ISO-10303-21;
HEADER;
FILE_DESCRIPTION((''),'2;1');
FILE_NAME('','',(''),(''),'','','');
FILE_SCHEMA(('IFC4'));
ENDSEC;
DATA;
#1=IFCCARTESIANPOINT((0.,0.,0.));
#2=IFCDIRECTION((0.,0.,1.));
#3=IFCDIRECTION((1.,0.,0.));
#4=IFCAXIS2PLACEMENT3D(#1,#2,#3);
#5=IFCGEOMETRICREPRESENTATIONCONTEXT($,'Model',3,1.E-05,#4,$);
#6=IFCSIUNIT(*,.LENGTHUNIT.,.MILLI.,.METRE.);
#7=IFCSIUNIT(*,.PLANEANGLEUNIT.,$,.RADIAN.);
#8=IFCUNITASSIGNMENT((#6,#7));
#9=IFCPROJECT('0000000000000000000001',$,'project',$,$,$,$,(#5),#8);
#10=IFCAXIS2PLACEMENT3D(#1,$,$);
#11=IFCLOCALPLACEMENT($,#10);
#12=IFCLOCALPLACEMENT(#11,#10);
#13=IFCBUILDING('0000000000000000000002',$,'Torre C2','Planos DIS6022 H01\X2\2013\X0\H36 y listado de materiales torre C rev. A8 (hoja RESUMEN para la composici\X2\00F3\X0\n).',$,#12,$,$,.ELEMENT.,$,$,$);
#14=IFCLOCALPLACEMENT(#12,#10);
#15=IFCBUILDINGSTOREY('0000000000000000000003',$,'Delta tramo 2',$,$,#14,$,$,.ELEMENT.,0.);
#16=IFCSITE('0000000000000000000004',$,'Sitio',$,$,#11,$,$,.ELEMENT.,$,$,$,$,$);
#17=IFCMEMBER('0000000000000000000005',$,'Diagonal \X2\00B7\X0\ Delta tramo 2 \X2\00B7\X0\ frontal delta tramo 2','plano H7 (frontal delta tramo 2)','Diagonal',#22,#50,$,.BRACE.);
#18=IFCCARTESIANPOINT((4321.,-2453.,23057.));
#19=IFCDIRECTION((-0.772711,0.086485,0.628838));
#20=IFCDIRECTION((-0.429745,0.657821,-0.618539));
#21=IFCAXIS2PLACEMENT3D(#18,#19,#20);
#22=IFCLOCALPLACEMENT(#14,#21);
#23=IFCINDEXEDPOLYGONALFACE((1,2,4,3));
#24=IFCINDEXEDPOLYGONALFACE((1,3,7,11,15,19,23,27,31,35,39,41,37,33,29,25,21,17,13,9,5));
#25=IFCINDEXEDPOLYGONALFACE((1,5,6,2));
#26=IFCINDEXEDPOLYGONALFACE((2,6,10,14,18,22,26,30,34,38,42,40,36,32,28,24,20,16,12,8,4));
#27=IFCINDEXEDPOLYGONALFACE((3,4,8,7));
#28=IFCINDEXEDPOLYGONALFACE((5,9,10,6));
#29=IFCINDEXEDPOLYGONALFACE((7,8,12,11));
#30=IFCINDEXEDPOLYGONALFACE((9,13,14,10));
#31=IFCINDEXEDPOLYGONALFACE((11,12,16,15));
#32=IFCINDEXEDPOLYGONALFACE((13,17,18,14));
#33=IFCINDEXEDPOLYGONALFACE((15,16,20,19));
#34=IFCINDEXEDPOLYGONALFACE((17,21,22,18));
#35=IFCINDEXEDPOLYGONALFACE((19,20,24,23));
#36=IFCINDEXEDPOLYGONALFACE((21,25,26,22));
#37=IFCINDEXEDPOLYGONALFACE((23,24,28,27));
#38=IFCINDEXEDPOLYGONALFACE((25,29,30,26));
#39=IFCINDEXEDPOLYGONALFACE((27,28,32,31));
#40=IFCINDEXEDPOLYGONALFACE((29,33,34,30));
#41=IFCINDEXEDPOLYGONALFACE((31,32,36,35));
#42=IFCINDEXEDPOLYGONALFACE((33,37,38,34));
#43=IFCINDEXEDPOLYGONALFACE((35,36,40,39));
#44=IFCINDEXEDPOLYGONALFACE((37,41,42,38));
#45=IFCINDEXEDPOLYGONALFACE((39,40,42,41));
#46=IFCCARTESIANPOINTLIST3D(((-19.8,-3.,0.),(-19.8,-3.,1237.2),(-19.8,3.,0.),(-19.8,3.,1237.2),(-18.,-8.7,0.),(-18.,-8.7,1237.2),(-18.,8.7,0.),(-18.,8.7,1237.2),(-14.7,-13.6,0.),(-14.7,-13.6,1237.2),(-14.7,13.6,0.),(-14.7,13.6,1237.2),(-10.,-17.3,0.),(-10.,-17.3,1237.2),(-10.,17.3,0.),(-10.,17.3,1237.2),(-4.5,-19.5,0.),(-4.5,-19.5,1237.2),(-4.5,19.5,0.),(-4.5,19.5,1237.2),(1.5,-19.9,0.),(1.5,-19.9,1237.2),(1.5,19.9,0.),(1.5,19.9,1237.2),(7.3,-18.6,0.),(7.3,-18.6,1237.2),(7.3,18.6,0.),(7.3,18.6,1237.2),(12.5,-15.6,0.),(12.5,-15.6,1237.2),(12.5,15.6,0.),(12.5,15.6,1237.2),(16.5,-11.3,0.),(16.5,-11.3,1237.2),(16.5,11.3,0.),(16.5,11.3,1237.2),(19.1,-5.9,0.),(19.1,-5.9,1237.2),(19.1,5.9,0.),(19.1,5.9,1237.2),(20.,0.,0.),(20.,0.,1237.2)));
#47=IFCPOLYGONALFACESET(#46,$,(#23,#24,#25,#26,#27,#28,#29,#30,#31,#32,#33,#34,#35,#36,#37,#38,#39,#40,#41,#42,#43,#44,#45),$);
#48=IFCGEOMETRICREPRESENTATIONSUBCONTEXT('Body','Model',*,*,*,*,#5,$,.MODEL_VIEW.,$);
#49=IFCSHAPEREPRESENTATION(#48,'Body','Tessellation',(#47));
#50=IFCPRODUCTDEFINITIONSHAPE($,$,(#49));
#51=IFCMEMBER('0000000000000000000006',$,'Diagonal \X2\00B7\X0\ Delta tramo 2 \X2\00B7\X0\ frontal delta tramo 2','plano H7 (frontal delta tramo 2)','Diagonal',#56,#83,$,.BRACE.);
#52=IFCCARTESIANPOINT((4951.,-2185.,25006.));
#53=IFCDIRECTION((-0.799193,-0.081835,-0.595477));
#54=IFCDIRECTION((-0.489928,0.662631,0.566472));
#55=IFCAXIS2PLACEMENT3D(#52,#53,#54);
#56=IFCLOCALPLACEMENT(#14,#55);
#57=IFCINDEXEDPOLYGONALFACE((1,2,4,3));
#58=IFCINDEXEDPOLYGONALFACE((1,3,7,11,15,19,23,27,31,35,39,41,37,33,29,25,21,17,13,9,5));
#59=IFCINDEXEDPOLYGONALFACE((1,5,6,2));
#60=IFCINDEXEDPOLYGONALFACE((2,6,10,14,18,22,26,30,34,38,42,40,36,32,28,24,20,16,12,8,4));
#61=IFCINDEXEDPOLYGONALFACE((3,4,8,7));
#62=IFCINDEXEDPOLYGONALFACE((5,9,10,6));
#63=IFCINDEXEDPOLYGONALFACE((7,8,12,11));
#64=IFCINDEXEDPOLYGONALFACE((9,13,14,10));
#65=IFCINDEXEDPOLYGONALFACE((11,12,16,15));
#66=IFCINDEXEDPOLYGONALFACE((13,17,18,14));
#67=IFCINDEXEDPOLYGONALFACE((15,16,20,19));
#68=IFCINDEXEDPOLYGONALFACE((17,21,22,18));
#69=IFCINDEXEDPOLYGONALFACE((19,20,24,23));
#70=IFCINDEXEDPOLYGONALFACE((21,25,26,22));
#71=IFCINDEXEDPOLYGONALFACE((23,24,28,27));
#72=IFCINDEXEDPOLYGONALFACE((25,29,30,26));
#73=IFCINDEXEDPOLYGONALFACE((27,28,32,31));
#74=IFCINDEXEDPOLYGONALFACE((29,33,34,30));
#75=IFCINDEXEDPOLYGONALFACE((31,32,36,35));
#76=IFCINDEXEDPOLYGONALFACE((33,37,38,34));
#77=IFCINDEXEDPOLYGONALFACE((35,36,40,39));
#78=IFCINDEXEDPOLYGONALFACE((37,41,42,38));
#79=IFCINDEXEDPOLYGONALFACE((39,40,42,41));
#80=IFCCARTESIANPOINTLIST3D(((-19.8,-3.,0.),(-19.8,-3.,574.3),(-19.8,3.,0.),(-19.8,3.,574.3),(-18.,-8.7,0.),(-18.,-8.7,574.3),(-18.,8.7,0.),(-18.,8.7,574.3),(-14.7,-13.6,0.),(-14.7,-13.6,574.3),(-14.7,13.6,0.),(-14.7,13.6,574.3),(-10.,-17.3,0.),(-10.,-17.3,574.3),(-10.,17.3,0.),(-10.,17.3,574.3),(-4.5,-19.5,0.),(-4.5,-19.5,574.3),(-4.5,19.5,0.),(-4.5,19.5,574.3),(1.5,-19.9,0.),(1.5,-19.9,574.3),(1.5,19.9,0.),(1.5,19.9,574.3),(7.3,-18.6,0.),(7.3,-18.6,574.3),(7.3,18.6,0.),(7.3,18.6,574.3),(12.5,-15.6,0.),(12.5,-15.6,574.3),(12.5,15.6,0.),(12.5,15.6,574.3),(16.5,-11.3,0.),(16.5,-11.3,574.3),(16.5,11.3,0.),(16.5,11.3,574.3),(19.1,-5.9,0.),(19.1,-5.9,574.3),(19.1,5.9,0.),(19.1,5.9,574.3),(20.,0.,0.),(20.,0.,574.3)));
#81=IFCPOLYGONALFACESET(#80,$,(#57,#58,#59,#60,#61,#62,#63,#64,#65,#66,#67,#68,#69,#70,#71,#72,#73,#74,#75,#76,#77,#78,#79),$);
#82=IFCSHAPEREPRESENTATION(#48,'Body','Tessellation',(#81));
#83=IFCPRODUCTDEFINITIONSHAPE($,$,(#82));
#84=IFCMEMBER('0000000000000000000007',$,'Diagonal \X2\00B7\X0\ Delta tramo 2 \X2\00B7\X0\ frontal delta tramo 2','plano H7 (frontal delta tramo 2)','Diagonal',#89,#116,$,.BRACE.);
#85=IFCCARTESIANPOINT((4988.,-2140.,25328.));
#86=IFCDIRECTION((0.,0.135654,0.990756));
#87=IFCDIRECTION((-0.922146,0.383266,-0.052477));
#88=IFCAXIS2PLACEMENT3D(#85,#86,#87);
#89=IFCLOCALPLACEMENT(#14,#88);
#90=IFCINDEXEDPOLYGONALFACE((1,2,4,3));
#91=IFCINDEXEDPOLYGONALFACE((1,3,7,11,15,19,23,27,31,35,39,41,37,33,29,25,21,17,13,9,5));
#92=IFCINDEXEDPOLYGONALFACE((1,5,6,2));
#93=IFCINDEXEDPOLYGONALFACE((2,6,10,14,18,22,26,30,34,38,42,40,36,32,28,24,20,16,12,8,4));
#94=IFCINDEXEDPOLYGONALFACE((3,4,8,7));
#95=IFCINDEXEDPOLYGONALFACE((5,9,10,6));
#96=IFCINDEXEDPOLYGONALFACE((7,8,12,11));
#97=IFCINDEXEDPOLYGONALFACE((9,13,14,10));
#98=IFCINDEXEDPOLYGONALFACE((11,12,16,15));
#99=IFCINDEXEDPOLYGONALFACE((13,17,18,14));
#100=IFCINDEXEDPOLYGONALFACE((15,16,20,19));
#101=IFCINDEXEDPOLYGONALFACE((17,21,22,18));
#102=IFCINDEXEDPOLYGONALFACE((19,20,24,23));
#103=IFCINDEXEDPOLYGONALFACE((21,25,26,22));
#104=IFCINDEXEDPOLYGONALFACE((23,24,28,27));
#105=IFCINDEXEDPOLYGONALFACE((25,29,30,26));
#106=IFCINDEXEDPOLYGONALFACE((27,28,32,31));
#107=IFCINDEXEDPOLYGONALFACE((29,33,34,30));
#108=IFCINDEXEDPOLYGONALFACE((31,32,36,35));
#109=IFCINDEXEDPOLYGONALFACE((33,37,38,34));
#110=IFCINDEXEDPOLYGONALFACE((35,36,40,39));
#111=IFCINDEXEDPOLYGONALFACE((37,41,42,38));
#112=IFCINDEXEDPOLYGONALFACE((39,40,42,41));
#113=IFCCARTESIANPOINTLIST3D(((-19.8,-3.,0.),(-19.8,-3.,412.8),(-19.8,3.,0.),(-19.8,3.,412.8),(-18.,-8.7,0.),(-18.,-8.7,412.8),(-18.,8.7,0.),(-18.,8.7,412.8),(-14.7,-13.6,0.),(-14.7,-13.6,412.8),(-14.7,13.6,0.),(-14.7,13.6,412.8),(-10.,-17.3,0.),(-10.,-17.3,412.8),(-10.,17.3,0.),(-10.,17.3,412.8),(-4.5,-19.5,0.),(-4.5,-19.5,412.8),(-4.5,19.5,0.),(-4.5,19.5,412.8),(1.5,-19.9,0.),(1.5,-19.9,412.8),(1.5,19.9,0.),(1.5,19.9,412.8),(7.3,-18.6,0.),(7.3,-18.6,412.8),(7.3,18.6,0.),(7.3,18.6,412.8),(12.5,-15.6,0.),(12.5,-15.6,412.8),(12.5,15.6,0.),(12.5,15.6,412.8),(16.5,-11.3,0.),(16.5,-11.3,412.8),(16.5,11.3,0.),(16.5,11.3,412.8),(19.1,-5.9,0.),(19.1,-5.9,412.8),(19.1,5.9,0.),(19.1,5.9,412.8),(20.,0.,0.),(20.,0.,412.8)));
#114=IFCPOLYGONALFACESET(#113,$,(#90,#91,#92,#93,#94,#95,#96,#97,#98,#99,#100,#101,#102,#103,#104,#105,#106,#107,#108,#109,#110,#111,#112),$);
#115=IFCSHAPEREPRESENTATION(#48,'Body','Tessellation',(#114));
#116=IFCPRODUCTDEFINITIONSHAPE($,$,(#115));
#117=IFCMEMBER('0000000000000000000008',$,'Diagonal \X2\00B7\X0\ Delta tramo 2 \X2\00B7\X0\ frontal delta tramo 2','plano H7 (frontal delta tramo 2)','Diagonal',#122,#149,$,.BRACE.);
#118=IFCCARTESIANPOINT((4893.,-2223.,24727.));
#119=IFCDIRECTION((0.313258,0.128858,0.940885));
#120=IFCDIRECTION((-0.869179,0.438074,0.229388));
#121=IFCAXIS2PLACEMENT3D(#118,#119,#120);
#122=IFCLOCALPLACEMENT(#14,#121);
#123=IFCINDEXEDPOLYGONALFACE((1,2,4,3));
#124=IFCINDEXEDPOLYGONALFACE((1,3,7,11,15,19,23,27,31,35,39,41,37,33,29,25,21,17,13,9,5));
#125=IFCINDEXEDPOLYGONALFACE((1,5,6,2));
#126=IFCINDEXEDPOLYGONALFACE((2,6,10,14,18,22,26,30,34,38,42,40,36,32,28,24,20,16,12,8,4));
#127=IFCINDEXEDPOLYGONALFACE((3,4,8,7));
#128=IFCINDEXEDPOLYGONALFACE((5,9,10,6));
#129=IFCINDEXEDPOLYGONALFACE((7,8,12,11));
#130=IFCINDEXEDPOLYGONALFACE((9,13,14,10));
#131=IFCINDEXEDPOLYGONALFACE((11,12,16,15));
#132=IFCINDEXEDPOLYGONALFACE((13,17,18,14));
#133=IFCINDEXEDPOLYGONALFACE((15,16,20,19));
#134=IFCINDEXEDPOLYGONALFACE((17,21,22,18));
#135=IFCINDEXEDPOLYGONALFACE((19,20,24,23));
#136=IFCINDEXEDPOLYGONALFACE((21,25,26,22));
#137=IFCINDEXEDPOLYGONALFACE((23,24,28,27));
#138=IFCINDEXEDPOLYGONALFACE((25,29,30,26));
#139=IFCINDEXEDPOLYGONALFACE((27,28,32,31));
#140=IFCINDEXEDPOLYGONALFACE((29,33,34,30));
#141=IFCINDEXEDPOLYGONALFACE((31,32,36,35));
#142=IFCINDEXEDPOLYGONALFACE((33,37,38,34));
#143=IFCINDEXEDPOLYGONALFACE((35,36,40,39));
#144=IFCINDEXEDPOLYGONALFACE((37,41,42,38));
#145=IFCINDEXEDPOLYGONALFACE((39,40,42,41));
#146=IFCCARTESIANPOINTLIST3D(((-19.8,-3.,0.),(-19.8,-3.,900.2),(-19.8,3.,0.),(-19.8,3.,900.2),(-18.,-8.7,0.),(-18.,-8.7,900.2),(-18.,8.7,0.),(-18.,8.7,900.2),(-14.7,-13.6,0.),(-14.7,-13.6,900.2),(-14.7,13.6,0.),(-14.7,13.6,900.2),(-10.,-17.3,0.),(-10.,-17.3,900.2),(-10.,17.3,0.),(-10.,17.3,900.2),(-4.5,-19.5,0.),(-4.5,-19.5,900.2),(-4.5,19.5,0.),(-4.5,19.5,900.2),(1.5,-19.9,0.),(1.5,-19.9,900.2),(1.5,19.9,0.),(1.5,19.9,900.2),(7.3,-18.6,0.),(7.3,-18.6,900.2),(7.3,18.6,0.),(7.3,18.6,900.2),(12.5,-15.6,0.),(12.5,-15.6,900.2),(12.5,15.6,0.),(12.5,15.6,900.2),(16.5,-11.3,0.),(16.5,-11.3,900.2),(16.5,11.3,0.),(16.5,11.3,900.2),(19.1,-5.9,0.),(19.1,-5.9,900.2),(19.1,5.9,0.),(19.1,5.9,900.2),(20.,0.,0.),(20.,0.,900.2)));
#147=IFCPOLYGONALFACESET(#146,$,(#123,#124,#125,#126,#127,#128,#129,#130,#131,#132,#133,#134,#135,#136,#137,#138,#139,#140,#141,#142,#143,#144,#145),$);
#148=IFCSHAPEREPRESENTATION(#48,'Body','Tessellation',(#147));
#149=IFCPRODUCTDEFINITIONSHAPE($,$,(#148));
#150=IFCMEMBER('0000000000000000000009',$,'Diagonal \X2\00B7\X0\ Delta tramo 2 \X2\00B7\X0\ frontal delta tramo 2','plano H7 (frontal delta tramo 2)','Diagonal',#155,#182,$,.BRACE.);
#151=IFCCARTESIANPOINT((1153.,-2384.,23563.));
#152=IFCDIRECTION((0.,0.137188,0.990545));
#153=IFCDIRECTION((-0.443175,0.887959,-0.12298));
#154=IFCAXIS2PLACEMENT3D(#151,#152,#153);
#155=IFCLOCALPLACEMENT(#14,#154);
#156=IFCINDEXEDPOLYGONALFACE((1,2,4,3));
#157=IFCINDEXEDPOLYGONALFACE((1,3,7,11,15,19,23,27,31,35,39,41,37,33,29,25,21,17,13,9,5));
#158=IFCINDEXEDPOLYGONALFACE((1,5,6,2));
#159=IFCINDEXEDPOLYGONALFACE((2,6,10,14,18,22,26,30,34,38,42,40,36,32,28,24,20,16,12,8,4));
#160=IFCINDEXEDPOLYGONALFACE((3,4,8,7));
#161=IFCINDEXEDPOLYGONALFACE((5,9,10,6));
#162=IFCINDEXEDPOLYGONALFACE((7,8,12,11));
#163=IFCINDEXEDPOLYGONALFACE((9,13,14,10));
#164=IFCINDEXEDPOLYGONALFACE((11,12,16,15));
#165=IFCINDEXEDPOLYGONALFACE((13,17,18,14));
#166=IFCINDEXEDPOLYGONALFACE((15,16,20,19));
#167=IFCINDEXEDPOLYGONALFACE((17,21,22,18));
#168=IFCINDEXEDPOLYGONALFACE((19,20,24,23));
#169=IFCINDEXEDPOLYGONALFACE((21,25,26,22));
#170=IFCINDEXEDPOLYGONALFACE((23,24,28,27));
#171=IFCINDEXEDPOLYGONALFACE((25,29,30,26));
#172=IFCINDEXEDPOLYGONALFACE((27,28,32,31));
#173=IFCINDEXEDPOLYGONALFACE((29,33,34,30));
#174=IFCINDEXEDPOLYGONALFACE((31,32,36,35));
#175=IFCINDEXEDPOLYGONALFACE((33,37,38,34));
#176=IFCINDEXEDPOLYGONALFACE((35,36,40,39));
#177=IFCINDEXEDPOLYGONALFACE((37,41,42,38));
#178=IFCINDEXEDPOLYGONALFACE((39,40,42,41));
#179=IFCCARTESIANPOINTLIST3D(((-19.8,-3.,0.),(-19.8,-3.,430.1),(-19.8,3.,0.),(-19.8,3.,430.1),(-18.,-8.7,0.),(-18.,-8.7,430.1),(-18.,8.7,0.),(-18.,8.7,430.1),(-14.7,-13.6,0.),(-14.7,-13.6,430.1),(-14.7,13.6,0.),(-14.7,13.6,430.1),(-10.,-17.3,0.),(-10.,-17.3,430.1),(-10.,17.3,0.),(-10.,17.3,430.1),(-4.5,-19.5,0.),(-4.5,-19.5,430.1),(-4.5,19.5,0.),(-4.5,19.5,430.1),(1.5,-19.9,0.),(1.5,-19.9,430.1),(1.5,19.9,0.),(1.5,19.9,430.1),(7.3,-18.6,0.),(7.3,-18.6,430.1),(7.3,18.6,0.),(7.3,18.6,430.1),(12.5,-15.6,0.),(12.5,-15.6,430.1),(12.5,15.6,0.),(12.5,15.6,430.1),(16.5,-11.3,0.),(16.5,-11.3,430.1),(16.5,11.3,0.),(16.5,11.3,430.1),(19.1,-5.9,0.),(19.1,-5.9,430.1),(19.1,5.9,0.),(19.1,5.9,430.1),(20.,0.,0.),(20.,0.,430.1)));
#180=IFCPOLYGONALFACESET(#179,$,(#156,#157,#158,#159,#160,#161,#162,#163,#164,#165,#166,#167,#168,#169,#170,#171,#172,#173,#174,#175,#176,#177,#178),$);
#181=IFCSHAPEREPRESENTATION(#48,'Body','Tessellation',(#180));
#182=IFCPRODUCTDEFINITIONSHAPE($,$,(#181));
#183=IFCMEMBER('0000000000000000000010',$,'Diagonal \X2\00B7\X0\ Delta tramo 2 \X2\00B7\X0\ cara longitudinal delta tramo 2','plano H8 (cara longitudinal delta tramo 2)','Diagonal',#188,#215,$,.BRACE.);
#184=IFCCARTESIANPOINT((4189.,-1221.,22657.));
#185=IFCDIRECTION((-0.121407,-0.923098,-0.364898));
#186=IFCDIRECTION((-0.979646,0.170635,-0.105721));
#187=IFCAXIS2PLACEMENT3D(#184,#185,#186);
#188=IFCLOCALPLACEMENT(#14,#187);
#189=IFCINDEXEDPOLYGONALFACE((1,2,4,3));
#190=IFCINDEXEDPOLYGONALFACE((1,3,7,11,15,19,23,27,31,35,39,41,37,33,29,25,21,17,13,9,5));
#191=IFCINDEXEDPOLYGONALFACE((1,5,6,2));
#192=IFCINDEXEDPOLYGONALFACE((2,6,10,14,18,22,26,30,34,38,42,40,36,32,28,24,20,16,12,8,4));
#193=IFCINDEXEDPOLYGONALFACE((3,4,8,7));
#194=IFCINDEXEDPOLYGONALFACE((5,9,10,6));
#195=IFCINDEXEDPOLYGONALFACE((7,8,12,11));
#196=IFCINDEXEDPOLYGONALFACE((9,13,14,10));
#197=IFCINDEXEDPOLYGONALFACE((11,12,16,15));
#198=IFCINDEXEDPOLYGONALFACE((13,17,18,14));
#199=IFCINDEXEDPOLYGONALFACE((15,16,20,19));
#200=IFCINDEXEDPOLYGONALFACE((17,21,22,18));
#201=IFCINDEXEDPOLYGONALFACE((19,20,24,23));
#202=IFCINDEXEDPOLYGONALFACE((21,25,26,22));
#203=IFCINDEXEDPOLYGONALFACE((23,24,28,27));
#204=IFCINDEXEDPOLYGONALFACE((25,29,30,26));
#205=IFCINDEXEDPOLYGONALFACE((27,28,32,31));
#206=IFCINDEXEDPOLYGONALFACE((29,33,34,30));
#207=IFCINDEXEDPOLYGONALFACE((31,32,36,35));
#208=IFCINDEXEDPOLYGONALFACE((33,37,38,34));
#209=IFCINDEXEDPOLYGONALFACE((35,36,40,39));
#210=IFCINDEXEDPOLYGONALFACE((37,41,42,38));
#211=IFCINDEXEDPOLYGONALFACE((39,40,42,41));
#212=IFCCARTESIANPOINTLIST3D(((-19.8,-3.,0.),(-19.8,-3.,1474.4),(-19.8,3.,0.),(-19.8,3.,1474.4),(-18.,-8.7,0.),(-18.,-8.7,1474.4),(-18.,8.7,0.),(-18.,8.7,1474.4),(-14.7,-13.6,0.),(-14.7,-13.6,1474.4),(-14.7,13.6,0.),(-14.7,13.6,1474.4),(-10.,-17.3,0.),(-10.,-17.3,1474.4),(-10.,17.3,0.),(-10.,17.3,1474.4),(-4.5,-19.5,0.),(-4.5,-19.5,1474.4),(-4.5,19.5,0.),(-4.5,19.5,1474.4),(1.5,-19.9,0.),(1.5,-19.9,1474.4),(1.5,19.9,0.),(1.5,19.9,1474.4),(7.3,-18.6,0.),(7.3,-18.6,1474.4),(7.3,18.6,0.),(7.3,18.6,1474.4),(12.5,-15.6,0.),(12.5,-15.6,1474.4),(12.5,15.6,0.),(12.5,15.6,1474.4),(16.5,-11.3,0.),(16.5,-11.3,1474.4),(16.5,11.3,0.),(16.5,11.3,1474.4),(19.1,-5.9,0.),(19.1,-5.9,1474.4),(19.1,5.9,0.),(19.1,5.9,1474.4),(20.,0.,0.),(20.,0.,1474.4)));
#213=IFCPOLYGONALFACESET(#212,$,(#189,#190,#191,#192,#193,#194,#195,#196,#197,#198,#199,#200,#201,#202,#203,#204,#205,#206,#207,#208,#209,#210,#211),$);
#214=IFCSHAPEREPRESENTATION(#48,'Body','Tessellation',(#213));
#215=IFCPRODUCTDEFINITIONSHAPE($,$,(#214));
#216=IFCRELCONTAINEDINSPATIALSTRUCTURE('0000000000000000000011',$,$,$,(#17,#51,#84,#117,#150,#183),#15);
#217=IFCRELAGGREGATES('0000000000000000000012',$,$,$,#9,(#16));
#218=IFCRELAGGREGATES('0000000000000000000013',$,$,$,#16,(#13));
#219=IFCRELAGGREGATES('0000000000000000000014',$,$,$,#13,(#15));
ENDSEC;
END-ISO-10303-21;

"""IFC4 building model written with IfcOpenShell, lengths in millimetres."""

from ifc_helpers import new_model, si_unit, frame, origin, origin_with_axes, place, context, subcontext, project, spatial, circle, extrude, element, save


model = new_model("IFC4")

# Units and contexts
model_context = context("Model", 3, precision=1e-05, world=origin_with_axes())
body_context = subcontext(model_context, "Body", "Model", "MODEL_VIEW")
ifc_project = project(units=[si_unit("LENGTHUNIT", "METRE", prefix="MILLI"), si_unit("PLANEANGLEUNIT", "RADIAN")], contexts=[model_context])

# Site, building, storey
site_placement = place(None, origin())
site = spatial("IfcSite", under=ifc_project, at=site_placement, Name="Sitio", CompositionType="ELEMENT")
building_placement = place(site_placement, origin())
building = spatial("IfcBuilding", under=site, at=building_placement, Name="Torre C2", Description="Planos DIS6022 H01–H36 y listado de materiales torre C rev. A8 (hoja RESUMEN para la composición).", CompositionType="ELEMENT")
storey_placement = place(building_placement, origin())
storey = spatial("IfcBuildingStorey", under=building, at=storey_placement, Name="Delta tramo 2", CompositionType="ELEMENT", Elevation=0.0)

# Members
member_1_placement = place(storey_placement, frame((4321.0, -2453.0, 23057.0), z_axis=(-0.772711, 0.086485, 0.628838), x_axis=(-0.429745, 0.657821, -0.618539)))
element("IfcMember", 1, at=member_1_placement, inside=storey, Name="Diagonal · Delta tramo 2 · frontal delta tramo 2", Description="plano H7 (frontal delta tramo 2)", ObjectType="Diagonal", PredefinedType="BRACE", context=body_context, shape_type="SweptSolid", body=[
    extrude(circle(Radius=20.0), None, (0.0, 0.0, 1.0), 1237.2),
])
member_2_placement = place(storey_placement, frame((4951.0, -2185.0, 25006.0), z_axis=(-0.799193, -0.081835, -0.595477), x_axis=(-0.489928, 0.662631, 0.566472)))
element("IfcMember", 2, at=member_2_placement, inside=storey, Name="Diagonal · Delta tramo 2 · frontal delta tramo 2", Description="plano H7 (frontal delta tramo 2)", ObjectType="Diagonal", PredefinedType="BRACE", context=body_context, shape_type="SweptSolid", body=[
    extrude(circle(Radius=20.0), None, (0.0, 0.0, 1.0), 574.3),
])
member_3_placement = place(storey_placement, frame((4988.0, -2140.0, 25328.0), z_axis=(0.0, 0.135654, 0.990756), x_axis=(-0.922146, 0.383266, -0.052477)))
element("IfcMember", 3, at=member_3_placement, inside=storey, Name="Diagonal · Delta tramo 2 · frontal delta tramo 2", Description="plano H7 (frontal delta tramo 2)", ObjectType="Diagonal", PredefinedType="BRACE", context=body_context, shape_type="SweptSolid", body=[
    extrude(circle(Radius=20.0), None, (0.0, 0.0, 1.0), 412.8),
])
member_4_placement = place(storey_placement, frame((4893.0, -2223.0, 24727.0), z_axis=(0.313258, 0.128858, 0.940885), x_axis=(-0.869179, 0.438074, 0.229388)))
element("IfcMember", 4, at=member_4_placement, inside=storey, Name="Diagonal · Delta tramo 2 · frontal delta tramo 2", Description="plano H7 (frontal delta tramo 2)", ObjectType="Diagonal", PredefinedType="BRACE", context=body_context, shape_type="SweptSolid", body=[
    extrude(circle(Radius=20.0), None, (0.0, 0.0, 1.0), 900.2),
])
for number, where, z_axis, x_axis, name in (
    (5, (1153.0, -2384.0, 23563.0), (0.0, 0.137188, 0.990545), (-0.443175, 0.887959, -0.12298), "Diagonal · Delta tramo 2 · frontal delta tramo 2"),
):
    element("IfcMember", number, at=place(storey_placement, frame(where, z_axis=z_axis, x_axis=x_axis)), inside=storey, Name=name, Description="plano H7 (frontal delta tramo 2)", ObjectType="Diagonal", PredefinedType="BRACE", context=body_context, shape_type="SweptSolid", body=[
        extrude(circle(Radius=20.0), None, (0.0, 0.0, 1.0), 430.1),
    ])
member_5_placement = place(storey_placement, frame((4189.0, -1221.0, 22657.0), z_axis=(-0.121407, -0.923098, -0.364898), x_axis=(-0.979646, 0.170635, -0.105721)))
element("IfcMember", 6, at=member_5_placement, inside=storey, Name="Diagonal · Delta tramo 2 · cara longitudinal delta tramo 2", Description="plano H8 (cara longitudinal delta tramo 2)", ObjectType="Diagonal", PredefinedType="BRACE", context=body_context, shape_type="SweptSolid", body=[
    extrude(circle(Radius=20.0), None, (0.0, 0.0, 1.0), 1474.4),
])

save(model, "model.ifc")
